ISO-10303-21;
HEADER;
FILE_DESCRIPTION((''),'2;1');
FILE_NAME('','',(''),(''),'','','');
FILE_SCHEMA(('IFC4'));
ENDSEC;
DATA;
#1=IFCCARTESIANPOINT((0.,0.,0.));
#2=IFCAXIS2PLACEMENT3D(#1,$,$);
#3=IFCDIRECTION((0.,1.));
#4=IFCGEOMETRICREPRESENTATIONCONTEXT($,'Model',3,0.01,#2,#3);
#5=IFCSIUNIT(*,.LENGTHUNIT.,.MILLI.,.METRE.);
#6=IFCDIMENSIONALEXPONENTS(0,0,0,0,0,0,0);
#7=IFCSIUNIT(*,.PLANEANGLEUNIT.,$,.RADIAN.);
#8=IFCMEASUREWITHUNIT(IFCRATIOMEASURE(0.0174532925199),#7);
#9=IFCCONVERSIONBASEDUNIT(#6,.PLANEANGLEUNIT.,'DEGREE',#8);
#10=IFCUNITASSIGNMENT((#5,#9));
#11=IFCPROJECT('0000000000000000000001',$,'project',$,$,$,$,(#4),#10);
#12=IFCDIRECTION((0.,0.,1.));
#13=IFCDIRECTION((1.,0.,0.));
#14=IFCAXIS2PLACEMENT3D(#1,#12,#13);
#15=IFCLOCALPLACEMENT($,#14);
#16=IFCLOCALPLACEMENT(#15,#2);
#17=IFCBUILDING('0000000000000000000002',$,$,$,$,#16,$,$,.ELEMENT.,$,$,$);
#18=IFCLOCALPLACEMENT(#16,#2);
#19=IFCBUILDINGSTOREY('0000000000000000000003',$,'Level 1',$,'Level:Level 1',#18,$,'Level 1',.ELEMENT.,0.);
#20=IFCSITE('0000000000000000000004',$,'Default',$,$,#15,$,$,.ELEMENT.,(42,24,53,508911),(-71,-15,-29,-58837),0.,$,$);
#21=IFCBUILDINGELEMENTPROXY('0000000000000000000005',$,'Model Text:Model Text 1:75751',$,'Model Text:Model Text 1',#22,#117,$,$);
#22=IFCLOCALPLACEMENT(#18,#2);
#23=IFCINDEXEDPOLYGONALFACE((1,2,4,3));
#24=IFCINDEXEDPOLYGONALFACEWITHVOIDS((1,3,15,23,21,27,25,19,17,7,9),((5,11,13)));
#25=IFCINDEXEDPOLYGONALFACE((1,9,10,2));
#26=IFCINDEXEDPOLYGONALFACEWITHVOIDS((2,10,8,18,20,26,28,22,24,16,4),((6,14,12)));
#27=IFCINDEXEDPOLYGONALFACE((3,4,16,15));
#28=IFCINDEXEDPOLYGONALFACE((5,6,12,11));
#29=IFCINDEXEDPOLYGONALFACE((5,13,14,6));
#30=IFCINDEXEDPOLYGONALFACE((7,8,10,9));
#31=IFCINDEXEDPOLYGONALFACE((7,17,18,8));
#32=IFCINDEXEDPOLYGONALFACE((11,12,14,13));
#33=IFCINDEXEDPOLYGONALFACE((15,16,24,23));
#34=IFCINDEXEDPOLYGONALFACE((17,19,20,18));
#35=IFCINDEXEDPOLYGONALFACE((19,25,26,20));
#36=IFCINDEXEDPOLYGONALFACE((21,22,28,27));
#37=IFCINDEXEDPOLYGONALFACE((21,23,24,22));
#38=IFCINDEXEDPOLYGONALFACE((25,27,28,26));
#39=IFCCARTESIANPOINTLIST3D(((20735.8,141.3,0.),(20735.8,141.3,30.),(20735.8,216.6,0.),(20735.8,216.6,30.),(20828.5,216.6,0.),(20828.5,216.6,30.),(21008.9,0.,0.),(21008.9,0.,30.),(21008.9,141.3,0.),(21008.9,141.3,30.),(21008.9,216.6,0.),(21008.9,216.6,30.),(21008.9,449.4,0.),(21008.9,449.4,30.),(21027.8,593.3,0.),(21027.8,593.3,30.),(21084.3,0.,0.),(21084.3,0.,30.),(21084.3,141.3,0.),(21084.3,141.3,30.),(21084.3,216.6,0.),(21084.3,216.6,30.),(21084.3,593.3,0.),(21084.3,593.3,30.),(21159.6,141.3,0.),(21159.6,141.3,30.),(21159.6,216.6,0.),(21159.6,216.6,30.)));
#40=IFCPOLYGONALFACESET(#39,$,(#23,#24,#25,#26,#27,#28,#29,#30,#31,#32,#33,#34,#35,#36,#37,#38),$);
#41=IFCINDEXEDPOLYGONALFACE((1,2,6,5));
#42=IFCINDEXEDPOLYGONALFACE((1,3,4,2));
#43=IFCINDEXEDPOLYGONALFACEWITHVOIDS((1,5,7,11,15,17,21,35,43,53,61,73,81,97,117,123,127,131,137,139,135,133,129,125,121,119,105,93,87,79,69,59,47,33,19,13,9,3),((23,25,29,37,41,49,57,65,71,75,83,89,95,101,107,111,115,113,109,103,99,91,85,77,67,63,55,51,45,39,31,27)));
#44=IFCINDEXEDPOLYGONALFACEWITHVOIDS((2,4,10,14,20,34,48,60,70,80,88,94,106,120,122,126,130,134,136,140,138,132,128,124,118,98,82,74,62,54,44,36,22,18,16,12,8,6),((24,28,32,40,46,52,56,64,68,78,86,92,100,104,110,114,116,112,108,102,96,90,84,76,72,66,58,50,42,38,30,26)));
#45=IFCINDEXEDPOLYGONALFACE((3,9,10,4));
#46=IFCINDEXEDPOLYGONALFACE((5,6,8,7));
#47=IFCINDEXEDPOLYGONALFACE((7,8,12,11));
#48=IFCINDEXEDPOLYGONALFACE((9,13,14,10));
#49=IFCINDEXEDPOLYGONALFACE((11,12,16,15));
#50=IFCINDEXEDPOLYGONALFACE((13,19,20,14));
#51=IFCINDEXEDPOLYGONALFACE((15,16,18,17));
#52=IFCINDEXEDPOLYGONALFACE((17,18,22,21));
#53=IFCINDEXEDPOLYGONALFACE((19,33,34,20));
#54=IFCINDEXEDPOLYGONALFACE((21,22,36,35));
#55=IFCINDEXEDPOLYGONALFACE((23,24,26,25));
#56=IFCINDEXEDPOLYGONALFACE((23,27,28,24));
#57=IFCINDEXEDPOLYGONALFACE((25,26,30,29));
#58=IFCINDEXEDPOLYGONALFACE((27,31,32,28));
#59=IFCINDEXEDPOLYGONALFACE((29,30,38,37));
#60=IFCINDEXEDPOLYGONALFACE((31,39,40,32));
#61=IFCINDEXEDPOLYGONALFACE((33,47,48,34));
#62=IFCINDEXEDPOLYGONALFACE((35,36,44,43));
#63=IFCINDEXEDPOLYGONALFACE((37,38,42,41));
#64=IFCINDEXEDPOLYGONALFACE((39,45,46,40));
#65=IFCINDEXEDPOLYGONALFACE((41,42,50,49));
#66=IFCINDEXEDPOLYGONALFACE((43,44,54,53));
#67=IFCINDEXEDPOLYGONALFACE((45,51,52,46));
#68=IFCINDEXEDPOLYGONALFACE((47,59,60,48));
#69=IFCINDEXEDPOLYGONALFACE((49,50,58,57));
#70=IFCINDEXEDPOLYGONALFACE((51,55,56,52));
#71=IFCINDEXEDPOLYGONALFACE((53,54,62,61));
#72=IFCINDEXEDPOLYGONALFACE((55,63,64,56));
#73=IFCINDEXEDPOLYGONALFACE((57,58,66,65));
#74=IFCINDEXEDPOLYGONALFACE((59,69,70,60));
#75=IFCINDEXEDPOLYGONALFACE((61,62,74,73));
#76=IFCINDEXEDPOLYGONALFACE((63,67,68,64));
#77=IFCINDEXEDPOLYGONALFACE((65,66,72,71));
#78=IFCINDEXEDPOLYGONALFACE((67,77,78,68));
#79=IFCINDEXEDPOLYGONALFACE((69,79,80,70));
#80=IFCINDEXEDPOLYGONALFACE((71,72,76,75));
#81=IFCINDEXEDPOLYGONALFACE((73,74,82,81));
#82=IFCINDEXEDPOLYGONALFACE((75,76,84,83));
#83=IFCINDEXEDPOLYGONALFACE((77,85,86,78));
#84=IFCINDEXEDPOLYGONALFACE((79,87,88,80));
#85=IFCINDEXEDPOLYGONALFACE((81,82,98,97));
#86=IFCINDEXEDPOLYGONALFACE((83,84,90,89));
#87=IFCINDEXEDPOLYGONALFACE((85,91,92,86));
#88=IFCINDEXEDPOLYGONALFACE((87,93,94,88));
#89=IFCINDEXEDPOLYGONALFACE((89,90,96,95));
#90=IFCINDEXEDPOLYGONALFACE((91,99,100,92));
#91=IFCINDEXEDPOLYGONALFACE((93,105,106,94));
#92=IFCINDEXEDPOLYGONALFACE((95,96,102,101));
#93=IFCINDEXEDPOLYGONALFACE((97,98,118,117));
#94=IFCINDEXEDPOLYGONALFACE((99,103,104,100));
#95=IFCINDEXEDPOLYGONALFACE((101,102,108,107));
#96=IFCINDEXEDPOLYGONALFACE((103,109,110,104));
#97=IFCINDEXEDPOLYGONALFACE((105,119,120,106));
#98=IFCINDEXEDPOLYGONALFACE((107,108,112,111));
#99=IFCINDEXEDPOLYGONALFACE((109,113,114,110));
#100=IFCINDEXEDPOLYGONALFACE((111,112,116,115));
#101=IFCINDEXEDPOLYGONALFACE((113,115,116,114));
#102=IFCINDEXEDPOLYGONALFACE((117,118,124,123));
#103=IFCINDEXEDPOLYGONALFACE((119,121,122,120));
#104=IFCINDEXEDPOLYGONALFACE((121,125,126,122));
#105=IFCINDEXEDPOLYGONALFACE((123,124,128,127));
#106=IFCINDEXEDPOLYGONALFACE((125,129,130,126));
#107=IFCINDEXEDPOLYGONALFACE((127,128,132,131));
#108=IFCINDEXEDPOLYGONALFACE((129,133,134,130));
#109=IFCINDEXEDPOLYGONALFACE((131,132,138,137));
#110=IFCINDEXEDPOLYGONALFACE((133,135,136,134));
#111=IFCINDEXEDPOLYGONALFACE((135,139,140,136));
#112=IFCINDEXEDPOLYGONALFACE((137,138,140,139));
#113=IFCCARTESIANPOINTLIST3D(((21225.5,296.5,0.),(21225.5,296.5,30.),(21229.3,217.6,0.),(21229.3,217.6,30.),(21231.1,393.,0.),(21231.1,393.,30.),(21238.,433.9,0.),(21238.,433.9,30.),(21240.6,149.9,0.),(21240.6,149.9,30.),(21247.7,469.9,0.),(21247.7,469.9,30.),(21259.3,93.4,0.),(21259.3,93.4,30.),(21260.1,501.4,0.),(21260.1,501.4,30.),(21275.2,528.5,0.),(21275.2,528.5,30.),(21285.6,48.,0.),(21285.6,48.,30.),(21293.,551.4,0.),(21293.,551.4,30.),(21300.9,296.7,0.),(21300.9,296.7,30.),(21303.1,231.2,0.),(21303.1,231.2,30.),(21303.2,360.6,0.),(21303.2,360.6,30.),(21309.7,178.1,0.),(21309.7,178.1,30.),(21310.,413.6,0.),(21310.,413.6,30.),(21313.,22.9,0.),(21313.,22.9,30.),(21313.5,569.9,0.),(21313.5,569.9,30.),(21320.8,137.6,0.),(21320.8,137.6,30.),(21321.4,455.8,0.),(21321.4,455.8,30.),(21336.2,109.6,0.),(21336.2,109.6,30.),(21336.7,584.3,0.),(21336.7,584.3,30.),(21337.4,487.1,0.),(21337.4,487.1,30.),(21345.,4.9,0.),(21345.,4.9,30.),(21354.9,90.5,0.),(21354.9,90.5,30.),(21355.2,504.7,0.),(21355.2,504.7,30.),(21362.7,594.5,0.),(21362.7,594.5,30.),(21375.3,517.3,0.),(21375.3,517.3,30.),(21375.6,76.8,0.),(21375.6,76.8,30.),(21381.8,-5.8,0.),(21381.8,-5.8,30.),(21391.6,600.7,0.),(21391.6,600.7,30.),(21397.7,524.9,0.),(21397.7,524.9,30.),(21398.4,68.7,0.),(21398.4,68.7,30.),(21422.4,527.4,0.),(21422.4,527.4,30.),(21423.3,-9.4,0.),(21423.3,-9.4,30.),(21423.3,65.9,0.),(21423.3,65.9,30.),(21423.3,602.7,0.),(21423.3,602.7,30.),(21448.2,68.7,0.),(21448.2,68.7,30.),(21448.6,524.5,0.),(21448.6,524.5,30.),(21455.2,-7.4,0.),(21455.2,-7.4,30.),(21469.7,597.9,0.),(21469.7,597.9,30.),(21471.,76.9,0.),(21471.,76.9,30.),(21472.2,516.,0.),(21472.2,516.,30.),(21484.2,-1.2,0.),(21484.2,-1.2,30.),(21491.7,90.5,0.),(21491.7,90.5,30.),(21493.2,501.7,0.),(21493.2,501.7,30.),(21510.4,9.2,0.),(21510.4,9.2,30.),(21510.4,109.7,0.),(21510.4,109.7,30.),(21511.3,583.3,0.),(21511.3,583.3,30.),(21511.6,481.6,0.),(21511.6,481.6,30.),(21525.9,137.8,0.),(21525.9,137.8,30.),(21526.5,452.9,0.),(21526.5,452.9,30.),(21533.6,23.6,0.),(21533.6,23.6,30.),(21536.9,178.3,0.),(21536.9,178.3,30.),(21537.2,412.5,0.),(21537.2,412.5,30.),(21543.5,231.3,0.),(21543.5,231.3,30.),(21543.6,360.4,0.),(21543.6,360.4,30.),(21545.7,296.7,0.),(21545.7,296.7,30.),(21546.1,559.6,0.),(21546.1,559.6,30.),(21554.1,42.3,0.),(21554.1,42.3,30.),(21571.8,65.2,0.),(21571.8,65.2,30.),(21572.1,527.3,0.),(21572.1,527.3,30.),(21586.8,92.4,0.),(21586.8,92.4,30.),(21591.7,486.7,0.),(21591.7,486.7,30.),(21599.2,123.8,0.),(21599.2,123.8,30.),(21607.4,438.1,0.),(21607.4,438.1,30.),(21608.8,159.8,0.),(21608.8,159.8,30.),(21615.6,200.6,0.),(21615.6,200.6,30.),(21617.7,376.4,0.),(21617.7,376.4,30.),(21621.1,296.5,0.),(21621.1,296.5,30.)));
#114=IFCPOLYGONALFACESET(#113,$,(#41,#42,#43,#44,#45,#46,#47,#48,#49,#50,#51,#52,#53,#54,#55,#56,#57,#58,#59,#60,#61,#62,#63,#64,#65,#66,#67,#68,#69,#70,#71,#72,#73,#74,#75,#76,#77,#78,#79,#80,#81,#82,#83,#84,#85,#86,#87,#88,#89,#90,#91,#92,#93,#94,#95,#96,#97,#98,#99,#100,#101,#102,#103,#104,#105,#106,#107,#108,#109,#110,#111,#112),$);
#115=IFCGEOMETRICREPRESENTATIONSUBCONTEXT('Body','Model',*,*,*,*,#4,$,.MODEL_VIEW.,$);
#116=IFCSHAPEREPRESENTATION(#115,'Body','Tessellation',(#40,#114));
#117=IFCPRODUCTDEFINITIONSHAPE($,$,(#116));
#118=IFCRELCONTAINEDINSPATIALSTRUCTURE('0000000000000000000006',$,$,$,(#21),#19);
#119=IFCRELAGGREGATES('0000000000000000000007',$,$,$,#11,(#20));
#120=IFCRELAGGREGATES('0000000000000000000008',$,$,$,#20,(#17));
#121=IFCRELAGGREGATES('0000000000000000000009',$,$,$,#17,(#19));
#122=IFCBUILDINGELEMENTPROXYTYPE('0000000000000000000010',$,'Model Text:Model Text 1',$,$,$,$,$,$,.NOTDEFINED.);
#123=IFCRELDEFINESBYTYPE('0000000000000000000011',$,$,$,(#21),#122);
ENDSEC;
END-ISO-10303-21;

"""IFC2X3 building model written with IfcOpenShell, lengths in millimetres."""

from ifc_helpers import new_model, entity, si_unit, converted_unit, direction, frame, origin, origin_with_axes, place, context, subcontext, project, spatial, polyline, outline, extrude, type_object, element, save


model = new_model("IFC2X3")

# Units and contexts
model_context = context("Model", 3, precision=0.01, world=origin(), true_north=direction((0.0, 1.0)))
body_context = subcontext(model_context, "Body", "Model", "MODEL_VIEW")
ifc_project = project(units=[si_unit("LENGTHUNIT", "METRE", prefix="MILLI"), converted_unit("PLANEANGLEUNIT", "DEGREE", entity("IfcRatioMeasure", 0.0174532925199), si_unit("PLANEANGLEUNIT", "RADIAN"), dimensions=[0, 0, 0, 0, 0, 0, 0])], contexts=[model_context])

# Site, building, storey
site_placement = place(None, origin_with_axes())
site = spatial("IfcSite", under=ifc_project, at=site_placement, Name="Default", CompositionType="ELEMENT", RefLatitude=(42, 24, 53, 508911), RefLongitude=(-71, -15, -29, -58837), RefElevation=0.0)
building_placement = place(site_placement, origin())
building = spatial("IfcBuilding", under=site, at=building_placement, CompositionType="ELEMENT")
storey_placement = place(building_placement, origin())
storey = spatial("IfcBuildingStorey", under=building, at=storey_placement, Name="Level 1", ObjectType="Level:Level 1", LongName="Level 1", CompositionType="ELEMENT", Elevation=0.0)

# Building element proxy
building_element_proxy_type_1 = type_object("IfcBuildingElementProxyType", Name="Model Text:Model Text 1", PredefinedType="NOTDEFINED")
proxy_1_placement = place(storey_placement, frame((20735.8, -9.4, 0.0)))
element("IfcBuildingElementProxy", 1, at=proxy_1_placement, inside=storey, type_object=building_element_proxy_type_1, Name="Model Text:Model Text 1:75751", ObjectType="Model Text:Model Text 1", context=body_context, shape_type="SweptSolid", body=[
    extrude(outline(polyline([(-6.8, -218.3), (68.5, -218.3), (68.5, -77.1), (143.8, -77.1), (143.8, -1.7), (68.5, -1.7), (68.5, 375.0), (12.0, 375.0), (-280.0, -1.7), (-280.0, -77.1), (-6.8, -77.1), (-6.8, -218.3)]), holes=[polyline([(-6.8, -1.7), (-187.3, -1.7), (-6.8, 231.1), (-6.8, -1.7)])]), frame((280.0, 227.7, 0.0)), (0.0, 0.0, 1.0), 30.0),
    extrude(outline(polyline([(-10.6, -198.7), (68.3, -198.7), (136.5, -190.7), (193.9, -174.7), (240.5, -150.6), (266.9, -124.4), (286.3, -93.2), (298.8, -57.0), (304.3, -15.7), (303.8, 16.2), (299.0, 45.5), (289.9, 72.1), (276.6, 96.0), (258.9, 117.3), (236.9, 136.2), (210.4, 152.5), (179.6, 166.3), (144.1, 177.6), (103.7, 186.3), (8.2, 196.4), (-71.8, 196.7), (-134.0, 189.4), (-183.3, 176.1), (-224.7, 158.4), (-258.2, 133.9), (-283.5, 100.3), (-300.1, 59.5), (-307.1, 13.4), (-306.6, -18.4), (-301.8, -47.5), (-292.8, -74.0), (-279.6, -97.9), (-262.0, -119.2), (-240.0, -138.1), (-213.6, -154.5), (-182.8, -168.4), (-147.3, -179.8), (-106.7, -188.6), (-10.6, -198.7)]), holes=[polyline([(-7.2, -123.5), (-71.0, -118.2), (-123.6, -108.8), (-165.2, -95.4), (-195.7, -78.0), (-212.4, -59.4), (-224.1, -38.7), (-230.6, -15.9), (-231.9, 8.9), (-227.8, 35.0), (-218.1, 58.1), (-202.8, 78.4), (-182.0, 95.8), (-152.6, 109.4), (-111.7, 118.1), (-59.4, 122.0), (4.4, 121.1), (69.6, 115.8), (122.2, 106.7), (162.2, 93.7), (189.5, 77.0), (207.7, 57.4), (220.4, 36.0), (227.5, 12.8), (229.1, -12.1), (225.2, -36.8), (215.9, -59.2), (201.3, -79.3), (181.4, -97.1), (152.6, -111.2), (111.6, -120.3), (58.3, -124.4), (-7.2, -123.5)])]), frame((688.7, 304.7, 0.0), z_axis=(0.0, 0.0, 1.0), x_axis=(0.047515, -0.998871, 0.0)), (0.0, 0.0, 1.0), 30.0),
])

save(model, "model.ifc")
